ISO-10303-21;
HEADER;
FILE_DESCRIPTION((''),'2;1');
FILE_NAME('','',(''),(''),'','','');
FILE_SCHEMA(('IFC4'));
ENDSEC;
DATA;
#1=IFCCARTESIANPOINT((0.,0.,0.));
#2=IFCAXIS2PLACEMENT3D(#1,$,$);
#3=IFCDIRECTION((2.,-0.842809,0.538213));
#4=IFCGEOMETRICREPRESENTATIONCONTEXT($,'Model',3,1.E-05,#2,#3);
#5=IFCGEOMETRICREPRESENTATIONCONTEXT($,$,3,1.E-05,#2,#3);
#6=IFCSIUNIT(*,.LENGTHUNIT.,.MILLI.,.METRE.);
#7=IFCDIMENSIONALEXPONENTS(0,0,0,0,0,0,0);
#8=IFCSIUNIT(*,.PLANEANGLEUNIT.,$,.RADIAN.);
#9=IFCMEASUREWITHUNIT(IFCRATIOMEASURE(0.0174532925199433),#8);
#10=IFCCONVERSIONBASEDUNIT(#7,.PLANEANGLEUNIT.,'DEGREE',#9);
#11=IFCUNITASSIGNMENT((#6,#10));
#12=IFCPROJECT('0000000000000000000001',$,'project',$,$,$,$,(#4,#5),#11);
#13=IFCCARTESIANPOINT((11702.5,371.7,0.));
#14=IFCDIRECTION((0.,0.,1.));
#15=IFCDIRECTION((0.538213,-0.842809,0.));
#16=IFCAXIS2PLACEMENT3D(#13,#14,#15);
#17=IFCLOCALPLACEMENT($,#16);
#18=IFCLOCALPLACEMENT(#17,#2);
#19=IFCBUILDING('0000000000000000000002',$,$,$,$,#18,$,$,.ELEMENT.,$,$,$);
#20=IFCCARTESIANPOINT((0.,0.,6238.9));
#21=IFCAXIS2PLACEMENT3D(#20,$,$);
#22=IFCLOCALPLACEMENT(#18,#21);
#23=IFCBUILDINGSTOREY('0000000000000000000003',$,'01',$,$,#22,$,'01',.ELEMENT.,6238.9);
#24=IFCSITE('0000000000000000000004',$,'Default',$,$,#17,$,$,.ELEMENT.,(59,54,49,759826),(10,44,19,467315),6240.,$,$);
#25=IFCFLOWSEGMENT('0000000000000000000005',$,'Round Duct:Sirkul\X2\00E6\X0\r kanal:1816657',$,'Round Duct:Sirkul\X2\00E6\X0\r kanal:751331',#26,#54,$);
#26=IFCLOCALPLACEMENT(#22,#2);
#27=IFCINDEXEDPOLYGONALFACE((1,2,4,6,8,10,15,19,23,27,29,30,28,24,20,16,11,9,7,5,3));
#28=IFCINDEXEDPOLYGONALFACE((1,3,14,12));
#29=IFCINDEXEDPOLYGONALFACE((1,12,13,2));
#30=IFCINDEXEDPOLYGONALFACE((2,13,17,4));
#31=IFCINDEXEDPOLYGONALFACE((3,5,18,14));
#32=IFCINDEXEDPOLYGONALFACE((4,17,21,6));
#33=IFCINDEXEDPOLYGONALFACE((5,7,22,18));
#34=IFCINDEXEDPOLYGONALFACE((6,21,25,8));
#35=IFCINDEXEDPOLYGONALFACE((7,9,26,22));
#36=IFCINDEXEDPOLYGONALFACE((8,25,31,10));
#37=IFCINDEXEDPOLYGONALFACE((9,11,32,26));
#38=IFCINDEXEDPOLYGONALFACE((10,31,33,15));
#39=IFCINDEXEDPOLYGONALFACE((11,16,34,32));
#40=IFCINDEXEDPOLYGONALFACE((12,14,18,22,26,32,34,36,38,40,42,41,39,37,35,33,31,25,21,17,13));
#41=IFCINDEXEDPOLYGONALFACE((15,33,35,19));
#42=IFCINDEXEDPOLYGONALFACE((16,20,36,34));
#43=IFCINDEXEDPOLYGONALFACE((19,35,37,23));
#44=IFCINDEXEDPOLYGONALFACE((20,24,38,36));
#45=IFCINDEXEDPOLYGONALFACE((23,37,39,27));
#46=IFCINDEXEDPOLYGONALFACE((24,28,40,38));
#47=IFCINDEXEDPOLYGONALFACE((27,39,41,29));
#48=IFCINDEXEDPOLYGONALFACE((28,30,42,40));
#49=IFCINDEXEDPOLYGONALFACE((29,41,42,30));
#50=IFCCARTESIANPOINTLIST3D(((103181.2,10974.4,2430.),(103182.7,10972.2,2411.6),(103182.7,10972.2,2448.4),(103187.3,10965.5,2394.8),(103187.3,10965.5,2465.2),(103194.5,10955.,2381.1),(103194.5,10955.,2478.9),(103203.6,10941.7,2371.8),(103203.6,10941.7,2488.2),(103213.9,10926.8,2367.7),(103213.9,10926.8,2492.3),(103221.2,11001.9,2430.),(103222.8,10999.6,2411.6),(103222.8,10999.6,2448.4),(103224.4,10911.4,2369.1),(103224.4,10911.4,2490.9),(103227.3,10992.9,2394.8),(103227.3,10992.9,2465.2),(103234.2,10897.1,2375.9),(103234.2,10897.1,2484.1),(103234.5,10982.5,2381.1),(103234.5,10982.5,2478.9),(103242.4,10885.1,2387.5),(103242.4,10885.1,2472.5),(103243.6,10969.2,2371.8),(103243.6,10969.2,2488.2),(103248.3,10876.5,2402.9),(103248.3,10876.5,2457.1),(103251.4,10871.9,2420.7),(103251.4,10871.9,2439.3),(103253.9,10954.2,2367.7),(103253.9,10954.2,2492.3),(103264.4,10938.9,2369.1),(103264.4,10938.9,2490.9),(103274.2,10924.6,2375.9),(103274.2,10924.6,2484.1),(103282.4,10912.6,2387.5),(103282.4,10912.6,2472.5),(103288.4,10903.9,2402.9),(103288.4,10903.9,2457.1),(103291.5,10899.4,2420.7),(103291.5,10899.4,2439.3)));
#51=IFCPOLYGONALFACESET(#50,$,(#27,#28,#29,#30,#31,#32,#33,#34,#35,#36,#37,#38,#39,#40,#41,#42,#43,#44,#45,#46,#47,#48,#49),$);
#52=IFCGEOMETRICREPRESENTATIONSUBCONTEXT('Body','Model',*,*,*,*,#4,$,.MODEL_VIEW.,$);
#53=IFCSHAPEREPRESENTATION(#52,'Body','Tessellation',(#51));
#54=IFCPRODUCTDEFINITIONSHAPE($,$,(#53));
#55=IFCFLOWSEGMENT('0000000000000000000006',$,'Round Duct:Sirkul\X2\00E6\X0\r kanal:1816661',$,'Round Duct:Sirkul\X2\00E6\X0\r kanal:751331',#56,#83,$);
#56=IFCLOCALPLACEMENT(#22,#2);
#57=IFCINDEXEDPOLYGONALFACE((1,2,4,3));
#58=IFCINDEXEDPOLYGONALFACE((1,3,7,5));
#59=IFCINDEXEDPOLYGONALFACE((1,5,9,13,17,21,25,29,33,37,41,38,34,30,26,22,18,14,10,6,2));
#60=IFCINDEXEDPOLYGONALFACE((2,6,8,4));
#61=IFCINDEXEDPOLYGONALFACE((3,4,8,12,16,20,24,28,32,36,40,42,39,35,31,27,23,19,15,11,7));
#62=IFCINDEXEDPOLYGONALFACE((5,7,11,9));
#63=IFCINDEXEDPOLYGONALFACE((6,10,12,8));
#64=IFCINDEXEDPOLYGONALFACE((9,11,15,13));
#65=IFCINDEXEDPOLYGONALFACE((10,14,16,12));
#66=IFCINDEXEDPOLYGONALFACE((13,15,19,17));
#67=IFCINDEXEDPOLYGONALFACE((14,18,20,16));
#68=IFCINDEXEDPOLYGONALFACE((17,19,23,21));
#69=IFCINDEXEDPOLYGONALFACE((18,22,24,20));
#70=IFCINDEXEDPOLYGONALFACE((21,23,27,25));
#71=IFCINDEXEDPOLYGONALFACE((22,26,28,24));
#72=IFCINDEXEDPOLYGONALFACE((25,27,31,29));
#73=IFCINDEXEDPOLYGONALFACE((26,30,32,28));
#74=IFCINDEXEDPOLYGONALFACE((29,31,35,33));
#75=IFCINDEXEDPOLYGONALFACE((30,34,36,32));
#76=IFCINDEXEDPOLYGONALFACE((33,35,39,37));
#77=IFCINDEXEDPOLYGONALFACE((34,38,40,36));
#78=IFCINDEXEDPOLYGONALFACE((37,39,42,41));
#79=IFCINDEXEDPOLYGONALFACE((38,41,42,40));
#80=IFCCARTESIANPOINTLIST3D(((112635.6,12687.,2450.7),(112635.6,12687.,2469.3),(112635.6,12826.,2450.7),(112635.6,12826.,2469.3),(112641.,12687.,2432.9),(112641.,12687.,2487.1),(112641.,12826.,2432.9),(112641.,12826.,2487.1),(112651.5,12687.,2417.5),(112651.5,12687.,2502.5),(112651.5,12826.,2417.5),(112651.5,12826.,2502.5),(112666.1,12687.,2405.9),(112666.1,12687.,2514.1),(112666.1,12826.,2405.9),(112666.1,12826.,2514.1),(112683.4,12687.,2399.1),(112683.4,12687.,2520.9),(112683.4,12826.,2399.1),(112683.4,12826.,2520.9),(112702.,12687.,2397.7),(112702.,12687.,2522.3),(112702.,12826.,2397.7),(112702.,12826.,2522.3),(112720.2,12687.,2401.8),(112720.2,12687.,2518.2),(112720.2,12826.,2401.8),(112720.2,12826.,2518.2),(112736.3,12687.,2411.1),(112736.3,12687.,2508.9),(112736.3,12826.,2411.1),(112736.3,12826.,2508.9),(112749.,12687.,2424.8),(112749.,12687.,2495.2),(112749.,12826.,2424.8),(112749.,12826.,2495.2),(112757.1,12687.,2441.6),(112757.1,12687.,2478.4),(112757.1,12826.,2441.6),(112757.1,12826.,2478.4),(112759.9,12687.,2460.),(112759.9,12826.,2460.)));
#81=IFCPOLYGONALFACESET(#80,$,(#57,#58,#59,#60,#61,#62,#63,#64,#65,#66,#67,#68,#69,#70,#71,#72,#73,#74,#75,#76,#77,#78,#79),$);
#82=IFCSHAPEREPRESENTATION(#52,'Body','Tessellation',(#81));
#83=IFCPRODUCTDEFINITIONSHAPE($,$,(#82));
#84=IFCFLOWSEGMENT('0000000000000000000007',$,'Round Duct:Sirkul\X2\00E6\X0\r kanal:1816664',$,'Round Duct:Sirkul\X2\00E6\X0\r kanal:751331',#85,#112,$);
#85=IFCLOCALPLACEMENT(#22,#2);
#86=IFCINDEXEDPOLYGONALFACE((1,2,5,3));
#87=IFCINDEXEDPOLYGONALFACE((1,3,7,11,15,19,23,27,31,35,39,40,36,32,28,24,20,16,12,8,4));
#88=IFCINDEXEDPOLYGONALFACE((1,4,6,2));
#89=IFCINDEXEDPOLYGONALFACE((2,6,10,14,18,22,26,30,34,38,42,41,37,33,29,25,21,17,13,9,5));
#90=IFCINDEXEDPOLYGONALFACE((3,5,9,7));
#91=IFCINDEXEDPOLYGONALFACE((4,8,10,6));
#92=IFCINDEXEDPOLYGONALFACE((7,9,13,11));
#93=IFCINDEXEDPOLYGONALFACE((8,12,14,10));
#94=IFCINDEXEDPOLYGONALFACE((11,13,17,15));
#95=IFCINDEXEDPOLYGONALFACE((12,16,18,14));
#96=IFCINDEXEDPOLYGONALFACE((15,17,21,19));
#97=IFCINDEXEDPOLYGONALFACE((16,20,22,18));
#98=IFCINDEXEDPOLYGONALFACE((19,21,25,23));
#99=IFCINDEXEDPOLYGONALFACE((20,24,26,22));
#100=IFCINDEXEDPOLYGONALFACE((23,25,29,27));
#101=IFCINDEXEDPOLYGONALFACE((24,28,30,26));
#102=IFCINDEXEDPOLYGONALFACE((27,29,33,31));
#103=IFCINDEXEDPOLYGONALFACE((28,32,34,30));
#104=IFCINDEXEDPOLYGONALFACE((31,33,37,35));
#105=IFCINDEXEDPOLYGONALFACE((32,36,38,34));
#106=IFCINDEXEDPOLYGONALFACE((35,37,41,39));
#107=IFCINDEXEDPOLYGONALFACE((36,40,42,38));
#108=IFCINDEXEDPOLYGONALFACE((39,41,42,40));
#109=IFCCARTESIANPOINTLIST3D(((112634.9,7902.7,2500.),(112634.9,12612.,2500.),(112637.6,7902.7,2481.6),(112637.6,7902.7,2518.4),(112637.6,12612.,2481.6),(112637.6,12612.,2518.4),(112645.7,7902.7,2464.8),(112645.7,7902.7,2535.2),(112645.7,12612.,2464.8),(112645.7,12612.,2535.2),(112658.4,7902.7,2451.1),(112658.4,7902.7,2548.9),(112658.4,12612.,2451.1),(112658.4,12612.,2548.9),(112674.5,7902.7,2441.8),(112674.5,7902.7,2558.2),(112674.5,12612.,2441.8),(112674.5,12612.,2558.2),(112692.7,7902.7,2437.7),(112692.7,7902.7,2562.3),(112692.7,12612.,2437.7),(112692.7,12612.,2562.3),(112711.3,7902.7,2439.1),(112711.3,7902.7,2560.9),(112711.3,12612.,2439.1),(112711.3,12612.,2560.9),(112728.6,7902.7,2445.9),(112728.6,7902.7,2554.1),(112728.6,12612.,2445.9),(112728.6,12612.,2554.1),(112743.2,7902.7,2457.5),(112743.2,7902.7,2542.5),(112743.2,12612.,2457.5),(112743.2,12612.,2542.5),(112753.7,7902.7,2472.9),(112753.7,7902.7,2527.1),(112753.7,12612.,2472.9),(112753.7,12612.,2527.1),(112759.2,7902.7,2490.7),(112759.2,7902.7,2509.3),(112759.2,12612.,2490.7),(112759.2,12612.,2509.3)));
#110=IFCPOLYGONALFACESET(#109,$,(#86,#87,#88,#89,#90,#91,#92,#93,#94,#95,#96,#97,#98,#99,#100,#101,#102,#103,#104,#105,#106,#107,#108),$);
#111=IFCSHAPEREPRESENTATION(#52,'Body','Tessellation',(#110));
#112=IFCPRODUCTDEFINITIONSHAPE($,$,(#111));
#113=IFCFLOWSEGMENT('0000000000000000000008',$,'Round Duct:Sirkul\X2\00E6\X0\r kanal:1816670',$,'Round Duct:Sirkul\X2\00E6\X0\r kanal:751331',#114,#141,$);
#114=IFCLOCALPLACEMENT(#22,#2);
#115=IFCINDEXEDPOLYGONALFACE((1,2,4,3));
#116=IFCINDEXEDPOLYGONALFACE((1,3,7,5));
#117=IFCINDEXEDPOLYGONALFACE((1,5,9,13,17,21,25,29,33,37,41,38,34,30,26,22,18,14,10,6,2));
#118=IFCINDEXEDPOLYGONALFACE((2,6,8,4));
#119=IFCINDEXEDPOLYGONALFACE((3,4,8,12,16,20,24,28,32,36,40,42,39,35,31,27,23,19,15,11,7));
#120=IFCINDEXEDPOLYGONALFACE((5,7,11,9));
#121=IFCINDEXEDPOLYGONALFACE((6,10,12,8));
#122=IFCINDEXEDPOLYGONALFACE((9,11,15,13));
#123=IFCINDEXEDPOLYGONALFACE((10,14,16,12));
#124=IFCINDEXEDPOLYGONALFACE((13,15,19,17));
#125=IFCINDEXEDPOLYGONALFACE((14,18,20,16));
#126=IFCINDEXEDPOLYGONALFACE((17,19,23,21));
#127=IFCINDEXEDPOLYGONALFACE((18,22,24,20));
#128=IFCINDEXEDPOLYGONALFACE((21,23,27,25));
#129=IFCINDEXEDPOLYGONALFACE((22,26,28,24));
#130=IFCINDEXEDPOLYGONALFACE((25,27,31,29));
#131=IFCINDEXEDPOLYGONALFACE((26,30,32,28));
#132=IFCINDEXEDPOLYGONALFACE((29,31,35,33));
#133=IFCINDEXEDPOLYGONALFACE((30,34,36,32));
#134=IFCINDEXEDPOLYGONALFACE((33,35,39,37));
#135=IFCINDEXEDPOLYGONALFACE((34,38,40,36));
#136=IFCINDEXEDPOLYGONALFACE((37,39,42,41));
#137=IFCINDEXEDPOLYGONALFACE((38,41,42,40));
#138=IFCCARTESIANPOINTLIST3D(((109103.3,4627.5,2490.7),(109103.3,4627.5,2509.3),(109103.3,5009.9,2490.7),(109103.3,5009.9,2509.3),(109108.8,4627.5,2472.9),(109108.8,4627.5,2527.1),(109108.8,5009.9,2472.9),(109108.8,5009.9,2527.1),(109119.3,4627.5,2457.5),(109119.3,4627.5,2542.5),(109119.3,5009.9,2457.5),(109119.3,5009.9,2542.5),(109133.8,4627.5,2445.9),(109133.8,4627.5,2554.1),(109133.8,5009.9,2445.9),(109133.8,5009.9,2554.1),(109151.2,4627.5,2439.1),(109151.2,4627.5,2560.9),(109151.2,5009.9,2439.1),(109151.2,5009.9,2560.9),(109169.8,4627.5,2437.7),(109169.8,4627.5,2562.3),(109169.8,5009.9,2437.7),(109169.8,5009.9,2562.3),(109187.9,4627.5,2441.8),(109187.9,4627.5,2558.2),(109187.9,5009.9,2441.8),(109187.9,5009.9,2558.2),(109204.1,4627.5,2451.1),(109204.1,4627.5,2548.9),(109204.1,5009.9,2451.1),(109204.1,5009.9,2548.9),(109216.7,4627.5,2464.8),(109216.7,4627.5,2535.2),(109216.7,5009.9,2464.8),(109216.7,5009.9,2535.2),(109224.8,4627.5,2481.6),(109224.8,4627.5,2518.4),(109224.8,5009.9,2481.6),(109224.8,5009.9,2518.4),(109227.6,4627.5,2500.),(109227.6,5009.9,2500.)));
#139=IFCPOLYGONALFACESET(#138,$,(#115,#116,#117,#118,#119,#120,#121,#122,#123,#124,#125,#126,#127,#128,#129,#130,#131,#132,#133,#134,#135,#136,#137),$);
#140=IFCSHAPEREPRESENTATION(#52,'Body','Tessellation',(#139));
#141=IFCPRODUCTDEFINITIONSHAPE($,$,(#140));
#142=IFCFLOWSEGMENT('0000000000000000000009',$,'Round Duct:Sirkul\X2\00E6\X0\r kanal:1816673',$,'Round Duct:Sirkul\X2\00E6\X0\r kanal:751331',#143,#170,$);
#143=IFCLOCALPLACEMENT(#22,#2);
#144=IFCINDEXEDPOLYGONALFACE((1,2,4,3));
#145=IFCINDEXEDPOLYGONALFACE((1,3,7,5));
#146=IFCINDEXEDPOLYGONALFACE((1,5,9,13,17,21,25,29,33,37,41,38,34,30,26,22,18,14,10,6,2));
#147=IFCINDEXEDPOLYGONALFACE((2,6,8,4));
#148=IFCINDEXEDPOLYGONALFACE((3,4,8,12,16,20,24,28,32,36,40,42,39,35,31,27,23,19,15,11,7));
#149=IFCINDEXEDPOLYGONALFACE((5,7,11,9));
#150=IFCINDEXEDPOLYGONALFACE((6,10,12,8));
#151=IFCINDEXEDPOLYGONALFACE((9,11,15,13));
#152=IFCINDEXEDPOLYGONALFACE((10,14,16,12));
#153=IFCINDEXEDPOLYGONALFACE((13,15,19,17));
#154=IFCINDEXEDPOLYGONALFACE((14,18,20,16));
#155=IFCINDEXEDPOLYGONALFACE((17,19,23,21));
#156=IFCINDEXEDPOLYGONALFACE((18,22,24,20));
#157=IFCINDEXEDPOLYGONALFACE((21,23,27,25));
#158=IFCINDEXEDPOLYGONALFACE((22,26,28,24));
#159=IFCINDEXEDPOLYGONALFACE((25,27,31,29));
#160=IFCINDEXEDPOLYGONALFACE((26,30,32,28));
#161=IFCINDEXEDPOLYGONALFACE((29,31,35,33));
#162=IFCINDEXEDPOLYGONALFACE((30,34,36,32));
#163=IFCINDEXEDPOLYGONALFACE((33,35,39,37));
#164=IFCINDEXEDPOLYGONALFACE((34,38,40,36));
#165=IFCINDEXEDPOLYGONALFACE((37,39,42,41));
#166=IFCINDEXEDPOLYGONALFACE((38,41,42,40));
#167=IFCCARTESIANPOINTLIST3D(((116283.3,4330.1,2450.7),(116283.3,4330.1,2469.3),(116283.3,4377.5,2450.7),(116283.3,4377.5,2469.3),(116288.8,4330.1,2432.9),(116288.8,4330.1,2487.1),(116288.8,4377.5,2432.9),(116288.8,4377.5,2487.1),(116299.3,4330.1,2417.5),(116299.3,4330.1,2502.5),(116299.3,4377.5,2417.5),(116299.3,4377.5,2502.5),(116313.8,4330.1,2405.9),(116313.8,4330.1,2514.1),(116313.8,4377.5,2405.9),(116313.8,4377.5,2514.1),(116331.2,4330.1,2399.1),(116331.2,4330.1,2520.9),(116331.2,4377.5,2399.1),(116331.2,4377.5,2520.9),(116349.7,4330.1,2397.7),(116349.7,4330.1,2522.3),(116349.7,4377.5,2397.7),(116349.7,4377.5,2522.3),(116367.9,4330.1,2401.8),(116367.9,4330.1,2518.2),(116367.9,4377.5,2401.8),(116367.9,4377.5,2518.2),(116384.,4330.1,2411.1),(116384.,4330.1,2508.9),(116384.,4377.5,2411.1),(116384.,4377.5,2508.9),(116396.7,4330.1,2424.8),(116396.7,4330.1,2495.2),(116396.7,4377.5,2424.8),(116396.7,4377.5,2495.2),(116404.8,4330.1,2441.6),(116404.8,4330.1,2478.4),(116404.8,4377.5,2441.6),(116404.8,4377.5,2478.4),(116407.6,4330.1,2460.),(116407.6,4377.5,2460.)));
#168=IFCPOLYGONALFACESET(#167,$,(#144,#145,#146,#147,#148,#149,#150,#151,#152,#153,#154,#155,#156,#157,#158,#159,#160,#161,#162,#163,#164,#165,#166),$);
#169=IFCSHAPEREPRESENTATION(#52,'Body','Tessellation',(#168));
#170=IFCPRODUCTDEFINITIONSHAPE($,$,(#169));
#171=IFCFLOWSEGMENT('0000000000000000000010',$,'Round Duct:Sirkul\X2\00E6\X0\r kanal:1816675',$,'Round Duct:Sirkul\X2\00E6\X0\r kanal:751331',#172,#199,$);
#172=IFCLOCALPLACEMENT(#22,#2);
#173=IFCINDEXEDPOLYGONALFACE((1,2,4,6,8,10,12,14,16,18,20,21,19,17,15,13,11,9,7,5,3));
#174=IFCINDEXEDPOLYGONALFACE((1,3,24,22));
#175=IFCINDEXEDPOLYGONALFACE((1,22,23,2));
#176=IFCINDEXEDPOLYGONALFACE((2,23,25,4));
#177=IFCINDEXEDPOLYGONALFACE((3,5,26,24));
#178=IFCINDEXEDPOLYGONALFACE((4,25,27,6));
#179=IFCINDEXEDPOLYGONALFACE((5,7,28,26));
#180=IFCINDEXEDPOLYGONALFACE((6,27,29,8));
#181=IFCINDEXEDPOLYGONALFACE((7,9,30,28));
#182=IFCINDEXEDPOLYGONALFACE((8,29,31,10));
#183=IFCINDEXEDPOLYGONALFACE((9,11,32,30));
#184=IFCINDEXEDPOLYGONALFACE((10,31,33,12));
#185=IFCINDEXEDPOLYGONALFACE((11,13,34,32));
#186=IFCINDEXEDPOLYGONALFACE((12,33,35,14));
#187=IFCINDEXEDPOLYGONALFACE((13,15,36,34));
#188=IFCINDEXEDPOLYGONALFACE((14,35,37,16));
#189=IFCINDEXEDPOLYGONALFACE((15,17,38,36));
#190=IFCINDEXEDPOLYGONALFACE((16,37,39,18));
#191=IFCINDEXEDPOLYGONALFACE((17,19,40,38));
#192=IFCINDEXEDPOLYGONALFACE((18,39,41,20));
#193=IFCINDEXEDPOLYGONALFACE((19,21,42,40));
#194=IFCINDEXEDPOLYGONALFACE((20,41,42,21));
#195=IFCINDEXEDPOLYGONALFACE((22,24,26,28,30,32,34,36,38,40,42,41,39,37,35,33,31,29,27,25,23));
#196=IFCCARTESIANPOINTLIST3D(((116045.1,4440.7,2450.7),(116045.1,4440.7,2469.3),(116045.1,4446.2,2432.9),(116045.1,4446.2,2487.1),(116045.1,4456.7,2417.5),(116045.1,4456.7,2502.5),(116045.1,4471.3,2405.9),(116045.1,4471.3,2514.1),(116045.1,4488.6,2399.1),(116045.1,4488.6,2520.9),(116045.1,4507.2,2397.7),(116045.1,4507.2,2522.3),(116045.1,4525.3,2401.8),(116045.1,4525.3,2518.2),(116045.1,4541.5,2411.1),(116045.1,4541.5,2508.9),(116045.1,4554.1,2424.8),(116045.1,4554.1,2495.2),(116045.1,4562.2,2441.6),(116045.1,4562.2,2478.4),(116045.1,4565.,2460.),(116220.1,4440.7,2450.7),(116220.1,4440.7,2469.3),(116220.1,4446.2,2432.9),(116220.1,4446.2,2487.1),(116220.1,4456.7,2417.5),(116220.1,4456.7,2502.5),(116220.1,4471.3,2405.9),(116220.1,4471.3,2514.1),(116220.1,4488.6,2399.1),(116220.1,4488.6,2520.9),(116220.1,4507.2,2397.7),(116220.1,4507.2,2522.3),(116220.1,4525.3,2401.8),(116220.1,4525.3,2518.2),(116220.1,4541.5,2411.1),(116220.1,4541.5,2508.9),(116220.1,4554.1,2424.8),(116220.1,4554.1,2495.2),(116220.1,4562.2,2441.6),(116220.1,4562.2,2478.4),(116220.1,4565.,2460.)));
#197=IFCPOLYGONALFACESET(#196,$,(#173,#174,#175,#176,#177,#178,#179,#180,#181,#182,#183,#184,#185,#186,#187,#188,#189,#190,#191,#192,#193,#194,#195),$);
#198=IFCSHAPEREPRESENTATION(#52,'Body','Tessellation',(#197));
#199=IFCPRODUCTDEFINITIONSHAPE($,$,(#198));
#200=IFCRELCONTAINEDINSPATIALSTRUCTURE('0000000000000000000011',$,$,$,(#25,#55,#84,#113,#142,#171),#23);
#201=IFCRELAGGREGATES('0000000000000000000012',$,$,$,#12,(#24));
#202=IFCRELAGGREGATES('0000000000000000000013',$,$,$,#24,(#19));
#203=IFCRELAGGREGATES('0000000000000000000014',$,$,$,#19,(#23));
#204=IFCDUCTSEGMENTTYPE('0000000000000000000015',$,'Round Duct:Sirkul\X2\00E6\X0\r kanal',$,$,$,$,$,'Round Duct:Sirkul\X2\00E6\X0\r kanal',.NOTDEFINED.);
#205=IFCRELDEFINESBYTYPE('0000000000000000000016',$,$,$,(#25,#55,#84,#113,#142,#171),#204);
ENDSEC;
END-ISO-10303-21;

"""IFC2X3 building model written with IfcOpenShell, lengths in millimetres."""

from ifc_helpers import new_model, entity, si_unit, converted_unit, direction, frame, frame_2d, origin, origin_2d_with_axis, place, context, subcontext, project, spatial, circle, extrude, type_object, element, save


model = new_model("IFC2X3")

# Units and contexts
model_context = context("Model", 3, precision=1e-05, world=origin(), true_north=direction((2.0, -0.842809, 0.538213)))
context_of_model = context(None, 3, precision=1e-05, world=origin(), true_north=direction((2.0, -0.842809, 0.538213)))
body_context = subcontext(model_context, "Body", "Model", "MODEL_VIEW")
ifc_project = project(units=[si_unit("LENGTHUNIT", "METRE", prefix="MILLI"), converted_unit("PLANEANGLEUNIT", "DEGREE", entity("IfcRatioMeasure", 0.0174532925199433), si_unit("PLANEANGLEUNIT", "RADIAN"), dimensions=[0, 0, 0, 0, 0, 0, 0])], contexts=[model_context, context_of_model])

# Site, building, storey
site_placement = place(None, frame((11702.5, 371.7, 0.0), z_axis=(0.0, 0.0, 1.0), x_axis=(0.538213, -0.842809, 0.0)))
site = spatial("IfcSite", under=ifc_project, at=site_placement, Name="Default", CompositionType="ELEMENT", RefLatitude=(59, 54, 49, 759826), RefLongitude=(10, 44, 19, 467315), RefElevation=6240.0)
building_placement = place(site_placement, origin())
building = spatial("IfcBuilding", under=site, at=building_placement, CompositionType="ELEMENT")
storey_placement = place(building_placement, frame((0.0, 0.0, 6238.9)))
storey = spatial("IfcBuildingStorey", under=building, at=storey_placement, Name="01", LongName="01", CompositionType="ELEMENT", Elevation=6238.9)

# Flow segments
duct_segment_type = type_object("IfcDuctSegmentType", Name="Round Duct:Sirkulær kanal", ElementType="Round Duct:Sirkulær kanal", PredefinedType="NOTDEFINED")
flow_segment_1_placement = place(storey_placement, origin())
element("IfcFlowSegment", 1, at=flow_segment_1_placement, inside=storey, type_object=duct_segment_type, Name="Round Duct:Sirkulær kanal:1816657", ObjectType="Round Duct:Sirkulær kanal:751331", context=body_context, shape_type="SweptSolid", body=[
    extrude(circle(Radius=62.5, at=frame_2d((0.0, 0.0), x_axis=(1.0, 0.0))), frame((103216.5, 10922.9, 2430.0), z_axis=(0.82474, 0.565513, 0.0), x_axis=(-0.565513, 0.82474, 0.0)), (0.0, 0.0, 1.0), 48.5),
])
flow_segment_2_placement = place(storey_placement, origin())
element("IfcFlowSegment", 2, at=flow_segment_2_placement, inside=storey, type_object=duct_segment_type, Name="Round Duct:Sirkulær kanal:1816661", ObjectType="Round Duct:Sirkulær kanal:751331", context=body_context, shape_type="SweptSolid", body=[
    extrude(circle(Radius=62.5, at=frame_2d((0.0, 0.0), x_axis=(1.0, 0.0))), frame((112697.4, 12687.0, 2460.0), z_axis=(0.0, 1.0, 0.0), x_axis=(1.0, 0.0, 0.0)), (0.0, 0.0, 1.0), 139.0),
])
flow_segment_3_placement = place(storey_placement, origin())
element("IfcFlowSegment", 3, at=flow_segment_3_placement, inside=storey, type_object=duct_segment_type, Name="Round Duct:Sirkulær kanal:1816664", ObjectType="Round Duct:Sirkulær kanal:751331", context=body_context, shape_type="SweptSolid", body=[
    extrude(circle(Radius=62.5, at=origin_2d_with_axis()), frame((112697.4, 7902.7, 2500.0), z_axis=(0.0, 1.0, 0.0), x_axis=(-1.0, 0.0, 0.0)), (0.0, 0.0, 1.0), 4709.3),
])
flow_segment_4_placement = place(storey_placement, origin())
element("IfcFlowSegment", 4, at=flow_segment_4_placement, inside=storey, type_object=duct_segment_type, Name="Round Duct:Sirkulær kanal:1816670", ObjectType="Round Duct:Sirkulær kanal:751331", context=body_context, shape_type="SweptSolid", body=[
    extrude(circle(Radius=62.5, at=origin_2d_with_axis()), frame((109165.1, 4627.5, 2500.0), z_axis=(0.000037, 1.0, 0.0), x_axis=(1.0, -0.000037, 0.0)), (0.0, 0.0, 1.0), 382.4),
])
flow_segment_5_placement = place(storey_placement, origin())
element("IfcFlowSegment", 5, at=flow_segment_5_placement, inside=storey, type_object=duct_segment_type, Name="Round Duct:Sirkulær kanal:1816673", ObjectType="Round Duct:Sirkulær kanal:751331", context=body_context, shape_type="SweptSolid", body=[
    extrude(circle(Radius=62.5, at=origin_2d_with_axis()), frame((116345.1, 4330.1, 2460.0), z_axis=(0.0, 1.0, 0.0), x_axis=(1.0, 0.0, 0.0)), (0.0, 0.0, 1.0), 47.4),
])
flow_segment_6_placement = place(storey_placement, origin())
element("IfcFlowSegment", 6, at=flow_segment_6_placement, inside=storey, type_object=duct_segment_type, Name="Round Duct:Sirkulær kanal:1816675", ObjectType="Round Duct:Sirkulær kanal:751331", context=body_context, shape_type="SweptSolid", body=[
    extrude(circle(Radius=62.5, at=frame_2d((0.0, 0.0), x_axis=(1.0, 0.0))), frame((116045.1, 4502.5, 2460.0), z_axis=(1.0, 0.0, 0.0), x_axis=(0.0, 1.0, 0.0)), (0.0, 0.0, 1.0), 175.0),
])

save(model, "model.ifc")
